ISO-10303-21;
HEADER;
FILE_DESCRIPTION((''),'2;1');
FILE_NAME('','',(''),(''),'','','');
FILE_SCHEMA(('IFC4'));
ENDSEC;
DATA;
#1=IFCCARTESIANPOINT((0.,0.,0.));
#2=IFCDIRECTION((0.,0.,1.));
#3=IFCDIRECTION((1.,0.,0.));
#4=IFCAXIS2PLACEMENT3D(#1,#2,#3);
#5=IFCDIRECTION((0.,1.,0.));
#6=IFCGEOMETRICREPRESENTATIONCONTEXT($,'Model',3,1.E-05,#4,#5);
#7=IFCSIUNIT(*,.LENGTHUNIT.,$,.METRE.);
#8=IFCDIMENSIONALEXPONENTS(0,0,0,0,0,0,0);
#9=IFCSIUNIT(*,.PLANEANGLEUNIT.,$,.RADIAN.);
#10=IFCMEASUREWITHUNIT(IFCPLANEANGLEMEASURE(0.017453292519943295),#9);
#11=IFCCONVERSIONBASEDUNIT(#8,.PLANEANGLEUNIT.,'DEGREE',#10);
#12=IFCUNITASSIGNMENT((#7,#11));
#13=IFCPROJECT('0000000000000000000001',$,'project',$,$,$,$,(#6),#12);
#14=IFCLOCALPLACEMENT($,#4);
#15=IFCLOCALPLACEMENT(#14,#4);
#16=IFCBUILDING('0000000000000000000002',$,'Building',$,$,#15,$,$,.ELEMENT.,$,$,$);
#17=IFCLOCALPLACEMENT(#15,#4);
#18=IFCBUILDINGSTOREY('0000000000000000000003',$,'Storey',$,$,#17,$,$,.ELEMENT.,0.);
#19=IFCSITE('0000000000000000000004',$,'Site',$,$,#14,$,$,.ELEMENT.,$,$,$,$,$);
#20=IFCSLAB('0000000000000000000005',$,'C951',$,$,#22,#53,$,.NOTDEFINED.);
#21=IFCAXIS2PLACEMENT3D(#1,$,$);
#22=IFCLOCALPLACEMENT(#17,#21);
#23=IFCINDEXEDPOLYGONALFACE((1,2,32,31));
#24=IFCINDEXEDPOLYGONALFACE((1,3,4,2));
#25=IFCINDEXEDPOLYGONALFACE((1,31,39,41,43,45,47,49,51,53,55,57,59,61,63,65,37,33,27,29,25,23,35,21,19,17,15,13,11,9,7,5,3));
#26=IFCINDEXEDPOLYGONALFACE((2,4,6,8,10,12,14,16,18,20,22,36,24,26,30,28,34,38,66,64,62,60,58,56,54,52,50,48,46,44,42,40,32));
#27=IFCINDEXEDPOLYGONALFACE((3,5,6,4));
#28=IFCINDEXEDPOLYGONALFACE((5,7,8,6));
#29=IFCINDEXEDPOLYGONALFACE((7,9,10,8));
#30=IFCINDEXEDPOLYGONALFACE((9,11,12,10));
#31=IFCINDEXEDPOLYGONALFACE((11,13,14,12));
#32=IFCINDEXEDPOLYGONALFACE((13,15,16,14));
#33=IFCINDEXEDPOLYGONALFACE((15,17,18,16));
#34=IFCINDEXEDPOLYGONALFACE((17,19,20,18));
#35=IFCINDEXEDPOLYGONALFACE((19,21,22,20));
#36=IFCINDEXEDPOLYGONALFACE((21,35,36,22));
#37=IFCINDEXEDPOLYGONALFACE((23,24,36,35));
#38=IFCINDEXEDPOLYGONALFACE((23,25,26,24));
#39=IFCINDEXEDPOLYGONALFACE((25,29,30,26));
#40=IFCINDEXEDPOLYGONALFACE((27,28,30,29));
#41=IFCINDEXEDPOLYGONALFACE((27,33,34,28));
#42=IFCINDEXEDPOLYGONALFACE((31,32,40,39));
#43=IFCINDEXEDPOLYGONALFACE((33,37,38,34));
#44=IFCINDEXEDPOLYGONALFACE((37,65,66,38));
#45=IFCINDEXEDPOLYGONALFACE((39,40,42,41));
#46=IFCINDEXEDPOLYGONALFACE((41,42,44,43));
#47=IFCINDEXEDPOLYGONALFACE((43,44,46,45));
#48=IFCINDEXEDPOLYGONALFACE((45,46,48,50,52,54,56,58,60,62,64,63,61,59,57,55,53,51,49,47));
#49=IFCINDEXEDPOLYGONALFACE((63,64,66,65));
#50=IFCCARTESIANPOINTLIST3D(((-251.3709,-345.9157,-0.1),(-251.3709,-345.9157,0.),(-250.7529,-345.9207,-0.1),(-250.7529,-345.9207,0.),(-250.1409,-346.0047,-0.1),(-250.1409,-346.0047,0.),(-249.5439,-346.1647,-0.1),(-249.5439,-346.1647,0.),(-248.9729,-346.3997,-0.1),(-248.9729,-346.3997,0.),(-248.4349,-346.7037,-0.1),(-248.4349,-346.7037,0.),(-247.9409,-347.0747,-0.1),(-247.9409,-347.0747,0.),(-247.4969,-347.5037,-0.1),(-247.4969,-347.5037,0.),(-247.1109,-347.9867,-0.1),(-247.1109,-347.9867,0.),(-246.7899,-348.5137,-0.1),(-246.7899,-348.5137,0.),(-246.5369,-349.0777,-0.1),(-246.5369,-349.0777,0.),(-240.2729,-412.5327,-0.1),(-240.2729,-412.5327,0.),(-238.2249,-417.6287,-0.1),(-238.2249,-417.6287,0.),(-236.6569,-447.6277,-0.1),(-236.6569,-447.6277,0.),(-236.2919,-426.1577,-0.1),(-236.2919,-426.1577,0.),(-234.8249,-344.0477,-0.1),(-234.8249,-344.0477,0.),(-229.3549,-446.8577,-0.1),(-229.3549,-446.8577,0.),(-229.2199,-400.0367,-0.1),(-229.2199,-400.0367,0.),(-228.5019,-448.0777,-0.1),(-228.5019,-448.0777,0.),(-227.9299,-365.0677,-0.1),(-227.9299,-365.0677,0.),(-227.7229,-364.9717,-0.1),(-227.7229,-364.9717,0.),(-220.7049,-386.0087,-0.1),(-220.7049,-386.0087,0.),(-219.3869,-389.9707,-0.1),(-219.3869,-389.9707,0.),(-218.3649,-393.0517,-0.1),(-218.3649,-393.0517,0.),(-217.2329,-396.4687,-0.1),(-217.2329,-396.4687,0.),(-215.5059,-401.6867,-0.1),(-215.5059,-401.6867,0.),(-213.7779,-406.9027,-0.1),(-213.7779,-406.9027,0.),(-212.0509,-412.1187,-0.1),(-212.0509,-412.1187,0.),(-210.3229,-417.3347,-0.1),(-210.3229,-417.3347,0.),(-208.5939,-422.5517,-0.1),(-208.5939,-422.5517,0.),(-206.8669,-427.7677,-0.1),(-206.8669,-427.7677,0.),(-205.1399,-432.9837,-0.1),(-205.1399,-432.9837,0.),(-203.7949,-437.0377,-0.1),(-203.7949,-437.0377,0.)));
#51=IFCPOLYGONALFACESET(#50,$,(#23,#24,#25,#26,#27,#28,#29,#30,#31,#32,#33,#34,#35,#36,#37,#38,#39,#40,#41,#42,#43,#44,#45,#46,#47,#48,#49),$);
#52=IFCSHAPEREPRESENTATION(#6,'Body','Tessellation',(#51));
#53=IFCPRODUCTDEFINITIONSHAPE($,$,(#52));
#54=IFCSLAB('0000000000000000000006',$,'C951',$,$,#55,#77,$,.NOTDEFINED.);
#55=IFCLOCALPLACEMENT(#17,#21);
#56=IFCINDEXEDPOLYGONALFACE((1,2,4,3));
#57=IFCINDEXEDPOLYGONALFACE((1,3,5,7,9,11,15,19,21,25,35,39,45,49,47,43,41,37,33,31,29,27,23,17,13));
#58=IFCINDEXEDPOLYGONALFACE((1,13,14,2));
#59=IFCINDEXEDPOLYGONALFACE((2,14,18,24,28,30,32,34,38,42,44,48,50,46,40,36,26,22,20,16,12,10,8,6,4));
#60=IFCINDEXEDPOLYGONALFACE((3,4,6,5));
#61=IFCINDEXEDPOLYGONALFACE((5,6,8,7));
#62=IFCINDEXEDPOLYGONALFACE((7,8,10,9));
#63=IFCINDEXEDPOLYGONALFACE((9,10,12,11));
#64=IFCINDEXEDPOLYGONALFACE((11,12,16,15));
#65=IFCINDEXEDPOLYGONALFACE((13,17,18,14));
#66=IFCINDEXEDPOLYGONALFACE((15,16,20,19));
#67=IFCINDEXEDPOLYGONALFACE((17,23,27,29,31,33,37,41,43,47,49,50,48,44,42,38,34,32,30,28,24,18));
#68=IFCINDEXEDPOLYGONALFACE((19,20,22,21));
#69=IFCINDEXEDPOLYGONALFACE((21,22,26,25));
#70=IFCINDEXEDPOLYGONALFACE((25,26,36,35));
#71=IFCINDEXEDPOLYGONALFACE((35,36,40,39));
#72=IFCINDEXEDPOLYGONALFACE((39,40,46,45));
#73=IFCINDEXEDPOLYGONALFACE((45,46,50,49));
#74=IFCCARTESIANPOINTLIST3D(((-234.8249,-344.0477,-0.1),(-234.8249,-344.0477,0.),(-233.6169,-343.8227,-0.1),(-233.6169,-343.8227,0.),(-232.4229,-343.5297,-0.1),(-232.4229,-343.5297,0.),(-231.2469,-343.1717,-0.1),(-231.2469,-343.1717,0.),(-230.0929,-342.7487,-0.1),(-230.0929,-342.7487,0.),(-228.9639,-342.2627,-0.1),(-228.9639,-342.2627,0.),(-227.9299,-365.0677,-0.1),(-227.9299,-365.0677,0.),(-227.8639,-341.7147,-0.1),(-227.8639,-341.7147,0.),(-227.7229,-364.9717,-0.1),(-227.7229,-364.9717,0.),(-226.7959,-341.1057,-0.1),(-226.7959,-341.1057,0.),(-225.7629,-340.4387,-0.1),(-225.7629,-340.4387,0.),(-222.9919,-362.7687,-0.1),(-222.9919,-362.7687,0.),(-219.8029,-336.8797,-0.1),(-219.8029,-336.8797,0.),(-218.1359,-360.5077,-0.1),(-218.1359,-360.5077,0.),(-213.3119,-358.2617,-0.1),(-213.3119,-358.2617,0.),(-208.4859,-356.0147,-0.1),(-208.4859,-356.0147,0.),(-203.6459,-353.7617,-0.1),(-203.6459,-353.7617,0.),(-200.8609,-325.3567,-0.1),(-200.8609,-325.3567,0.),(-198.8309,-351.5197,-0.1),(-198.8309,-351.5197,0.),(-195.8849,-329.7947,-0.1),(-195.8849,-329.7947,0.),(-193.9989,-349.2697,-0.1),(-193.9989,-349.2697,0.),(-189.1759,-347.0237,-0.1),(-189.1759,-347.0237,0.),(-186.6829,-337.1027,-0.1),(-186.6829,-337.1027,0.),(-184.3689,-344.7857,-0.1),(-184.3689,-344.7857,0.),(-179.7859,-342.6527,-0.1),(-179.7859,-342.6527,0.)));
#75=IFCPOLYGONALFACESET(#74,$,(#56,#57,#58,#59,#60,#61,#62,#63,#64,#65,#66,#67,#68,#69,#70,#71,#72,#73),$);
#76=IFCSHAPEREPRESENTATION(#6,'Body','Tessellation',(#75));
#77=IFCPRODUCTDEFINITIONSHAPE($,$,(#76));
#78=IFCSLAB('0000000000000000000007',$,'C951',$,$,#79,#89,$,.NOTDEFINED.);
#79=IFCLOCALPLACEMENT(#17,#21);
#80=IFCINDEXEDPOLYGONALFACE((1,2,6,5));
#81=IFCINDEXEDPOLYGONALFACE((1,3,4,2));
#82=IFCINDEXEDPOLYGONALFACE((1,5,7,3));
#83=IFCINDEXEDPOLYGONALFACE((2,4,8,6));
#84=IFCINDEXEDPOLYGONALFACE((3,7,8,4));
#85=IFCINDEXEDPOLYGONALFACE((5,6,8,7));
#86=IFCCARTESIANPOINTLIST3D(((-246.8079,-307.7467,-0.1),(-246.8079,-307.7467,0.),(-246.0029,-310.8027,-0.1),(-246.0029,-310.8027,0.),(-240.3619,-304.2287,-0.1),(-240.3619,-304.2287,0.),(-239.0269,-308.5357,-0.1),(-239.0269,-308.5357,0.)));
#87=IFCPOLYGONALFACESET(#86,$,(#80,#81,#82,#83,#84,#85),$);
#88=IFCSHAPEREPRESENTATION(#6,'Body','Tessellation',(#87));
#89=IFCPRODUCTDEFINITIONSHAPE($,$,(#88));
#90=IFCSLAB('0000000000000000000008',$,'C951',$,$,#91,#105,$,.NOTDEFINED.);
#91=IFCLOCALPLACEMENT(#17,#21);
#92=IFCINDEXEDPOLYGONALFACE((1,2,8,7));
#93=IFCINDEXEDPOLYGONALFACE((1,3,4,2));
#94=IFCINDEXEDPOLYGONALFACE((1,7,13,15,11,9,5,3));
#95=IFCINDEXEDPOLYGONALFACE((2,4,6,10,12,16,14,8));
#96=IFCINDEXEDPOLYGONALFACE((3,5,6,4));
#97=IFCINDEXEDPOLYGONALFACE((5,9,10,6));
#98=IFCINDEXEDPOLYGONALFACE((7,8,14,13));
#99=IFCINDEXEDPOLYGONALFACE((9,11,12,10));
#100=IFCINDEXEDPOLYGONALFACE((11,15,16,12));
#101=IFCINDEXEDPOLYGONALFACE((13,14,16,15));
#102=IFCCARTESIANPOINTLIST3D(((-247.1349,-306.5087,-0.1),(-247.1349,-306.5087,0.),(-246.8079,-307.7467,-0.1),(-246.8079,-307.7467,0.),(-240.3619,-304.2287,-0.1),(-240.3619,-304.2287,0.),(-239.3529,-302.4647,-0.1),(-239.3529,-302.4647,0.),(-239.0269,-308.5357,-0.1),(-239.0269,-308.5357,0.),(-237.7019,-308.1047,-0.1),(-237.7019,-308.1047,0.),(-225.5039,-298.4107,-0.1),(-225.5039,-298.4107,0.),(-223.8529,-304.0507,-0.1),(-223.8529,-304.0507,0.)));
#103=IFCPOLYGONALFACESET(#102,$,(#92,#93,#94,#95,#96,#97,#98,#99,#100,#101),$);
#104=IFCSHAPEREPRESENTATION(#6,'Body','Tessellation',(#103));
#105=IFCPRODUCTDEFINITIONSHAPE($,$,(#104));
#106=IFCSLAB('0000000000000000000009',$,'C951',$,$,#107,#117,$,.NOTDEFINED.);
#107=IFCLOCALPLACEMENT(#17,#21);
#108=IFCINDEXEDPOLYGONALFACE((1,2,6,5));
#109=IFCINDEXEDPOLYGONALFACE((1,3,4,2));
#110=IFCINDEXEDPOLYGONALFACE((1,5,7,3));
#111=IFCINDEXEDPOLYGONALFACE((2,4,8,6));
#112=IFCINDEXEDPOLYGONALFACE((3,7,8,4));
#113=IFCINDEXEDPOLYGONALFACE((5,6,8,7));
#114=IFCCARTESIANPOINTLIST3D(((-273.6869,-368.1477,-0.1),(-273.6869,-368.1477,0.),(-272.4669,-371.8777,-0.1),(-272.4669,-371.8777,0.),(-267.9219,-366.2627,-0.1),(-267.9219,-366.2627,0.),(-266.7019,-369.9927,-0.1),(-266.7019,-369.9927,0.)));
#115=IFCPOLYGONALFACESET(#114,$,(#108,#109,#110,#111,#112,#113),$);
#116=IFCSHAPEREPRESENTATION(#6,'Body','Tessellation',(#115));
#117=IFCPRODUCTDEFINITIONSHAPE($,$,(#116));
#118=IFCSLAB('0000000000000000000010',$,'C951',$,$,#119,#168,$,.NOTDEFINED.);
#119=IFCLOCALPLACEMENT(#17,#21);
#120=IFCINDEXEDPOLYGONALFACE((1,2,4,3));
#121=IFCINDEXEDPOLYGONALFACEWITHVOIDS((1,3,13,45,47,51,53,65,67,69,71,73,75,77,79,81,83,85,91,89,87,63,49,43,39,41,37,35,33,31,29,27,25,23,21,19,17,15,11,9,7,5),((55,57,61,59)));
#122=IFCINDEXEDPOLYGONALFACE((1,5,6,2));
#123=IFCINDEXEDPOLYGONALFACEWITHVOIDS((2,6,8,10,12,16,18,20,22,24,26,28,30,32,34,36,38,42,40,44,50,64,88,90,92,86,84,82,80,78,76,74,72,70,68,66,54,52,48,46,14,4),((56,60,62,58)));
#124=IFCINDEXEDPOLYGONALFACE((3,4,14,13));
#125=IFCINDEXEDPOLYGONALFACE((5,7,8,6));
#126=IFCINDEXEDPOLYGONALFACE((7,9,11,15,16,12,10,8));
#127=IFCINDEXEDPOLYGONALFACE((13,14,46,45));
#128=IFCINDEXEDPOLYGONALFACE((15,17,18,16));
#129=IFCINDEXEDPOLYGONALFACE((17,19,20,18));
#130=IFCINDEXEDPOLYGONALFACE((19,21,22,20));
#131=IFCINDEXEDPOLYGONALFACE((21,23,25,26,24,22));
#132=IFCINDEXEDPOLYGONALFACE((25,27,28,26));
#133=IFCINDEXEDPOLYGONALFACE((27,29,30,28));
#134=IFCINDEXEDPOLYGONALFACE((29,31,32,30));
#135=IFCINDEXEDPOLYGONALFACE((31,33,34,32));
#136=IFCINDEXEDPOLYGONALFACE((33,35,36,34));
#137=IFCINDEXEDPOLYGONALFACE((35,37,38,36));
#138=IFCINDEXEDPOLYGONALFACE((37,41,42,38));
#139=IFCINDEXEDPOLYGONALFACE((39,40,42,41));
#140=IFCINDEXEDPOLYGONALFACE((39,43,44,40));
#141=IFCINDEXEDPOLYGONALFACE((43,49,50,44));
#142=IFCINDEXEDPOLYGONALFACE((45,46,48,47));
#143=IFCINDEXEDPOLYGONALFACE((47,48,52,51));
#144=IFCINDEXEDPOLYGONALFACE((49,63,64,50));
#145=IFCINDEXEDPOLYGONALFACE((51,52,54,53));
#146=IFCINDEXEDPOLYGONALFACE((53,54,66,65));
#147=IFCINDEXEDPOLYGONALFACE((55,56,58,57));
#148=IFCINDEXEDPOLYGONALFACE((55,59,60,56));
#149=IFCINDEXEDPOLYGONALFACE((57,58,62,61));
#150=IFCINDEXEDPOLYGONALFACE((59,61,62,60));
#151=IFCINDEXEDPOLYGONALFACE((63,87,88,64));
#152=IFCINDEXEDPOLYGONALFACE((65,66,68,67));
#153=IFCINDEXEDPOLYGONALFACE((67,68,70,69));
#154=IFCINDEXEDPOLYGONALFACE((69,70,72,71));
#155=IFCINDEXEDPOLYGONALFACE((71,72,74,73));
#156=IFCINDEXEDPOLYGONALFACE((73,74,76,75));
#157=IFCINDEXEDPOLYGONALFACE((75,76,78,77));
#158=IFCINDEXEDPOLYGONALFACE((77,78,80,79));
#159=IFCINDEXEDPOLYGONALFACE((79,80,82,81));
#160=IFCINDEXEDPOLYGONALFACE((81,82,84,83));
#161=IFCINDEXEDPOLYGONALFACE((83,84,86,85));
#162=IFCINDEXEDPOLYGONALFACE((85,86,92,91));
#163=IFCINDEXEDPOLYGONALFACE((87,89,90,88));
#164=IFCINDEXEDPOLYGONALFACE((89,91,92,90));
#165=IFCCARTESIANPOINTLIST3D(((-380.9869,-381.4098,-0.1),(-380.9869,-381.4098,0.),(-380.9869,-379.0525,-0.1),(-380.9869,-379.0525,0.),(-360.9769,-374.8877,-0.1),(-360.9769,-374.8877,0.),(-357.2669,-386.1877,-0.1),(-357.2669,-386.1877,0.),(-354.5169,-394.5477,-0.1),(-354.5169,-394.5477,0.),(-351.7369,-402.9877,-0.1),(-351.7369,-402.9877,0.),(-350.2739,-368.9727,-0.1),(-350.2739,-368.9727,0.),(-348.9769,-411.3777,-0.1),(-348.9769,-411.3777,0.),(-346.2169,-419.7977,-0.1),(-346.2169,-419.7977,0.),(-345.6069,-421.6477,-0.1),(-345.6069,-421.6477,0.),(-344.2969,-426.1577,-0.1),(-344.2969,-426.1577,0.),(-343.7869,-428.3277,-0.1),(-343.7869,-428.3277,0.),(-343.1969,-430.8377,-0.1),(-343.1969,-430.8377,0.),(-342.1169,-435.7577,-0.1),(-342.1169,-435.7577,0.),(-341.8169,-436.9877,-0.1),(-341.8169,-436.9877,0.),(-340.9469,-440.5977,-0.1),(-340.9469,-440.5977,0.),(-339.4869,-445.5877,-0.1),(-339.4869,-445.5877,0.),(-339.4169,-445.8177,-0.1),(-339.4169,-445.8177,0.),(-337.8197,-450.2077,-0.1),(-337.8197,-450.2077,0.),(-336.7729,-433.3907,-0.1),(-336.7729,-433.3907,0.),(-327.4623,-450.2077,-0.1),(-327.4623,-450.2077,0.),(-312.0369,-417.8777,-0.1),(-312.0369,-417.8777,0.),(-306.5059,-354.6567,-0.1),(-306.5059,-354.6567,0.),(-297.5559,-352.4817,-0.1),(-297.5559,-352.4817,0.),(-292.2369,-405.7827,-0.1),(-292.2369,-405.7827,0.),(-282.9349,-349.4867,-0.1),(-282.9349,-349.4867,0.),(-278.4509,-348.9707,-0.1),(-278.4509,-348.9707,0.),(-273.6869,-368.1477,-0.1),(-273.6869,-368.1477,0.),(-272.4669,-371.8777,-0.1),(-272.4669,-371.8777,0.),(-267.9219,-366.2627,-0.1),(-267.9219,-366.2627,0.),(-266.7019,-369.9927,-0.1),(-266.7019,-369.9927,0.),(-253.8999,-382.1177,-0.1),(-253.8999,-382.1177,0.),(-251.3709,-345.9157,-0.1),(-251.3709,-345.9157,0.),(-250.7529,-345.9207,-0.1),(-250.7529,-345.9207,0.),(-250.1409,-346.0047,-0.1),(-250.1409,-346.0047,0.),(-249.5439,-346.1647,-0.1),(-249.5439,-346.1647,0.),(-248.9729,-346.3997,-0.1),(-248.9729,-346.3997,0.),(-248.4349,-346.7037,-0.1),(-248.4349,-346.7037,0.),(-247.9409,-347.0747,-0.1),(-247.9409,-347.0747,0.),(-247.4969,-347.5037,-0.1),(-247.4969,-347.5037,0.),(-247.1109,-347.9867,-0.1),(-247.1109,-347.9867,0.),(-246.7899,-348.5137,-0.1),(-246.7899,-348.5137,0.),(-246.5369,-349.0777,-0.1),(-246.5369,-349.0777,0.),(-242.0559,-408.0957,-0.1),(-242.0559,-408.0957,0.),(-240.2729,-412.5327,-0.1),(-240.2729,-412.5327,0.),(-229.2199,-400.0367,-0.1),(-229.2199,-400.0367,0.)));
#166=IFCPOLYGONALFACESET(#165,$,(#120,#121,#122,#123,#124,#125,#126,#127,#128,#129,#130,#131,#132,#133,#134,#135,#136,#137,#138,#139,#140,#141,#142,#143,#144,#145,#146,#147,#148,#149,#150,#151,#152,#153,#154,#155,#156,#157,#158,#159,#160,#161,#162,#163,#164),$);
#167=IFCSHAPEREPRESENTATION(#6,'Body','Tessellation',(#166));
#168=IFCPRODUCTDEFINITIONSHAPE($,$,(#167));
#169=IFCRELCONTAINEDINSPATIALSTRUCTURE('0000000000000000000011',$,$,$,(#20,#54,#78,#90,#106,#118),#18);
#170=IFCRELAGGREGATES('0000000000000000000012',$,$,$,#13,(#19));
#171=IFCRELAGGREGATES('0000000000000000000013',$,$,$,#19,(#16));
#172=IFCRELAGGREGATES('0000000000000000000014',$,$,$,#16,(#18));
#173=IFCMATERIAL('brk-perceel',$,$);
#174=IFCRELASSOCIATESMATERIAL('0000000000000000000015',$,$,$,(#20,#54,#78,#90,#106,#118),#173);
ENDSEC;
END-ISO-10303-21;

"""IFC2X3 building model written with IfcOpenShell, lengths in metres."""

from ifc_helpers import new_model, entity, si_unit, converted_unit, direction, frame, origin_with_axes, place, context, project, spatial, polyline, outline, extrude, material, element, save


model = new_model("IFC2X3")

# Units and contexts
model_context = context("Model", 3, precision=1e-05, world=origin_with_axes(), true_north=direction((0.0, 1.0, 0.0)))
ifc_project = project(units=[si_unit("LENGTHUNIT", "METRE"), converted_unit("PLANEANGLEUNIT", "DEGREE", entity("IfcPlaneAngleMeasure", 0.017453292519943295), si_unit("PLANEANGLEUNIT", "RADIAN"), dimensions=[0, 0, 0, 0, 0, 0, 0])], contexts=[model_context])

# Site, building, storey
site_placement = place(None, origin_with_axes())
site = spatial("IfcSite", under=ifc_project, at=site_placement, Name="Site", CompositionType="ELEMENT")
building_placement = place(site_placement, origin_with_axes())
building = spatial("IfcBuilding", under=site, at=building_placement, Name="Building", CompositionType="ELEMENT")
storey_placement = place(building_placement, origin_with_axes())
storey = spatial("IfcBuildingStorey", under=building, at=storey_placement, Name="Storey", CompositionType="ELEMENT", Elevation=0.0)

# Slabs
ifc_material = material(Name="brk-perceel")
slab_1_placement = place(storey_placement, frame((0.0, 0.0, -0.1), z_axis=(0.0, 0.0, 1.0), x_axis=(1.0, 0.0, 0.0)))
element("IfcSlab", 1, at=slab_1_placement, inside=storey, material=ifc_material, Name="C951", PredefinedType="NOTDEFINED", context=model_context, shape_type="SweptSolid", body=[
    extrude(outline(polyline([(-218.3649, -393.0517), (-217.2329, -396.4687), (-215.5059, -401.6867), (-213.7779, -406.9027), (-212.0509, -412.1187), (-210.3229, -417.3347), (-208.5939, -422.5517), (-206.8669, -427.7677), (-205.1399, -432.9837), (-203.7949, -437.0377), (-228.5019, -448.0777), (-229.3549, -446.8577), (-236.6569, -447.6277), (-236.2919, -426.1577), (-238.2249, -417.6287), (-240.2729, -412.5327), (-229.2199, -400.0367), (-246.5369, -349.0777), (-246.7899, -348.5137), (-247.1109, -347.9867), (-247.4969, -347.5037), (-247.9409, -347.0747), (-248.4349, -346.7037), (-248.9729, -346.3997), (-249.5439, -346.1647), (-250.1409, -346.0047), (-250.7529, -345.9207), (-251.3709, -345.9157), (-234.8249, -344.0477), (-227.9299, -365.0677), (-227.7229, -364.9717), (-220.7049, -386.0087), (-219.3869, -389.9707), (-218.3649, -393.0517)])), origin_with_axes(), (0.0, 0.0, 1.0), 0.1),
])
slab_2_placement = place(storey_placement, frame((0.0, 0.0, -0.1), z_axis=(0.0, 0.0, 1.0), x_axis=(1.0, 0.0, 0.0)))
element("IfcSlab", 2, at=slab_2_placement, inside=storey, material=ifc_material, Name="C951", PredefinedType="NOTDEFINED", context=model_context, shape_type="SweptSolid", body=[
    extrude(outline(polyline([(-208.4859, -356.0147), (-213.3119, -358.2617), (-218.1359, -360.5077), (-222.9919, -362.7687), (-227.7229, -364.9717), (-227.9299, -365.0677), (-234.8249, -344.0477), (-233.6169, -343.8227), (-232.4229, -343.5297), (-231.2469, -343.1717), (-230.0929, -342.7487), (-228.9639, -342.2627), (-227.8639, -341.7147), (-226.7959, -341.1057), (-225.7629, -340.4387), (-219.8029, -336.8797), (-200.8609, -325.3567), (-195.8849, -329.7947), (-186.6829, -337.1027), (-179.7859, -342.6527), (-184.3689, -344.7857), (-189.1759, -347.0237), (-193.9989, -349.2697), (-198.8309, -351.5197), (-203.6459, -353.7617), (-208.4859, -356.0147)])), origin_with_axes(), (0.0, 0.0, 1.0), 0.1),
])
slab_3_placement = place(storey_placement, frame((0.0, 0.0, -0.1), z_axis=(0.0, 0.0, 1.0), x_axis=(1.0, 0.0, 0.0)))
element("IfcSlab", 3, at=slab_3_placement, inside=storey, material=ifc_material, Name="C951", PredefinedType="NOTDEFINED", context=model_context, shape_type="SweptSolid", body=[
    extrude(outline(polyline([(-240.3619, -304.2287), (-239.0269, -308.5357), (-246.0029, -310.8027), (-246.8079, -307.7467), (-240.3619, -304.2287)])), origin_with_axes(), (0.0, 0.0, 1.0), 0.1),
])
slab_4_placement = place(storey_placement, frame((0.0, 0.0, -0.1), z_axis=(0.0, 0.0, 1.0), x_axis=(1.0, 0.0, 0.0)))
element("IfcSlab", 4, at=slab_4_placement, inside=storey, material=ifc_material, Name="C951", PredefinedType="NOTDEFINED", context=model_context, shape_type="SweptSolid", body=[
    extrude(outline(polyline([(-223.8529, -304.0507), (-237.7019, -308.1047), (-239.0269, -308.5357), (-240.3619, -304.2287), (-246.8079, -307.7467), (-247.1349, -306.5087), (-239.3529, -302.4647), (-225.5039, -298.4107), (-223.8529, -304.0507)])), origin_with_axes(), (0.0, 0.0, 1.0), 0.1),
])
slab_5_placement = place(storey_placement, frame((0.0, 0.0, -0.1), z_axis=(0.0, 0.0, 1.0), x_axis=(1.0, 0.0, 0.0)))
element("IfcSlab", 5, at=slab_5_placement, inside=storey, material=ifc_material, Name="C951", PredefinedType="NOTDEFINED", context=model_context, shape_type="SweptSolid", body=[
    extrude(outline(polyline([(-273.6869, -368.1477), (-267.9219, -366.2627), (-266.7019, -369.9927), (-272.4669, -371.8777), (-273.6869, -368.1477)])), origin_with_axes(), (0.0, 0.0, 1.0), 0.1),
])
slab_6_placement = place(storey_placement, frame((0.0, 0.0, -0.1), z_axis=(0.0, 0.0, 1.0), x_axis=(1.0, 0.0, 0.0)))
element("IfcSlab", 6, at=slab_6_placement, inside=storey, material=ifc_material, Name="C951", PredefinedType="NOTDEFINED", context=model_context, shape_type="SweptSolid", body=[
    extrude(outline(polyline([(-339.4169, -445.8177), (-339.4869, -445.5877), (-340.9469, -440.5977), (-341.8169, -436.9877), (-342.1169, -435.7577), (-343.1969, -430.8377), (-343.7869, -428.3277), (-344.2969, -426.1577), (-345.6069, -421.6477), (-346.2169, -419.7977), (-348.9769, -411.3777), (-351.7369, -402.9877), (-354.5169, -394.5477), (-357.2669, -386.1877), (-360.9769, -374.8877), (-380.9869, -381.4098), (-380.9869, -379.0525), (-350.2739, -368.9727), (-306.5059, -354.6567), (-297.5559, -352.4817), (-282.9349, -349.4867), (-278.4509, -348.9707), (-251.3709, -345.9157), (-250.7529, -345.9207), (-250.1409, -346.0047), (-249.5439, -346.1647), (-248.9729, -346.3997), (-248.4349, -346.7037), (-247.9409, -347.0747), (-247.4969, -347.5037), (-247.1109, -347.9867), (-246.7899, -348.5137), (-246.5369, -349.0777), (-229.2199, -400.0367), (-240.2729, -412.5327), (-242.0559, -408.0957), (-253.8999, -382.1177), (-292.2369, -405.7827), (-312.0369, -417.8777), (-336.7729, -433.3907), (-327.4623, -450.2077), (-337.8197, -450.2077), (-339.4169, -445.8177)]), holes=[polyline([(-266.7019, -369.9927), (-267.9219, -366.2627), (-273.6869, -368.1477), (-272.4669, -371.8777), (-266.7019, -369.9927)])]), origin_with_axes(), (0.0, 0.0, 1.0), 0.1),
])

save(model, "model.ifc")
